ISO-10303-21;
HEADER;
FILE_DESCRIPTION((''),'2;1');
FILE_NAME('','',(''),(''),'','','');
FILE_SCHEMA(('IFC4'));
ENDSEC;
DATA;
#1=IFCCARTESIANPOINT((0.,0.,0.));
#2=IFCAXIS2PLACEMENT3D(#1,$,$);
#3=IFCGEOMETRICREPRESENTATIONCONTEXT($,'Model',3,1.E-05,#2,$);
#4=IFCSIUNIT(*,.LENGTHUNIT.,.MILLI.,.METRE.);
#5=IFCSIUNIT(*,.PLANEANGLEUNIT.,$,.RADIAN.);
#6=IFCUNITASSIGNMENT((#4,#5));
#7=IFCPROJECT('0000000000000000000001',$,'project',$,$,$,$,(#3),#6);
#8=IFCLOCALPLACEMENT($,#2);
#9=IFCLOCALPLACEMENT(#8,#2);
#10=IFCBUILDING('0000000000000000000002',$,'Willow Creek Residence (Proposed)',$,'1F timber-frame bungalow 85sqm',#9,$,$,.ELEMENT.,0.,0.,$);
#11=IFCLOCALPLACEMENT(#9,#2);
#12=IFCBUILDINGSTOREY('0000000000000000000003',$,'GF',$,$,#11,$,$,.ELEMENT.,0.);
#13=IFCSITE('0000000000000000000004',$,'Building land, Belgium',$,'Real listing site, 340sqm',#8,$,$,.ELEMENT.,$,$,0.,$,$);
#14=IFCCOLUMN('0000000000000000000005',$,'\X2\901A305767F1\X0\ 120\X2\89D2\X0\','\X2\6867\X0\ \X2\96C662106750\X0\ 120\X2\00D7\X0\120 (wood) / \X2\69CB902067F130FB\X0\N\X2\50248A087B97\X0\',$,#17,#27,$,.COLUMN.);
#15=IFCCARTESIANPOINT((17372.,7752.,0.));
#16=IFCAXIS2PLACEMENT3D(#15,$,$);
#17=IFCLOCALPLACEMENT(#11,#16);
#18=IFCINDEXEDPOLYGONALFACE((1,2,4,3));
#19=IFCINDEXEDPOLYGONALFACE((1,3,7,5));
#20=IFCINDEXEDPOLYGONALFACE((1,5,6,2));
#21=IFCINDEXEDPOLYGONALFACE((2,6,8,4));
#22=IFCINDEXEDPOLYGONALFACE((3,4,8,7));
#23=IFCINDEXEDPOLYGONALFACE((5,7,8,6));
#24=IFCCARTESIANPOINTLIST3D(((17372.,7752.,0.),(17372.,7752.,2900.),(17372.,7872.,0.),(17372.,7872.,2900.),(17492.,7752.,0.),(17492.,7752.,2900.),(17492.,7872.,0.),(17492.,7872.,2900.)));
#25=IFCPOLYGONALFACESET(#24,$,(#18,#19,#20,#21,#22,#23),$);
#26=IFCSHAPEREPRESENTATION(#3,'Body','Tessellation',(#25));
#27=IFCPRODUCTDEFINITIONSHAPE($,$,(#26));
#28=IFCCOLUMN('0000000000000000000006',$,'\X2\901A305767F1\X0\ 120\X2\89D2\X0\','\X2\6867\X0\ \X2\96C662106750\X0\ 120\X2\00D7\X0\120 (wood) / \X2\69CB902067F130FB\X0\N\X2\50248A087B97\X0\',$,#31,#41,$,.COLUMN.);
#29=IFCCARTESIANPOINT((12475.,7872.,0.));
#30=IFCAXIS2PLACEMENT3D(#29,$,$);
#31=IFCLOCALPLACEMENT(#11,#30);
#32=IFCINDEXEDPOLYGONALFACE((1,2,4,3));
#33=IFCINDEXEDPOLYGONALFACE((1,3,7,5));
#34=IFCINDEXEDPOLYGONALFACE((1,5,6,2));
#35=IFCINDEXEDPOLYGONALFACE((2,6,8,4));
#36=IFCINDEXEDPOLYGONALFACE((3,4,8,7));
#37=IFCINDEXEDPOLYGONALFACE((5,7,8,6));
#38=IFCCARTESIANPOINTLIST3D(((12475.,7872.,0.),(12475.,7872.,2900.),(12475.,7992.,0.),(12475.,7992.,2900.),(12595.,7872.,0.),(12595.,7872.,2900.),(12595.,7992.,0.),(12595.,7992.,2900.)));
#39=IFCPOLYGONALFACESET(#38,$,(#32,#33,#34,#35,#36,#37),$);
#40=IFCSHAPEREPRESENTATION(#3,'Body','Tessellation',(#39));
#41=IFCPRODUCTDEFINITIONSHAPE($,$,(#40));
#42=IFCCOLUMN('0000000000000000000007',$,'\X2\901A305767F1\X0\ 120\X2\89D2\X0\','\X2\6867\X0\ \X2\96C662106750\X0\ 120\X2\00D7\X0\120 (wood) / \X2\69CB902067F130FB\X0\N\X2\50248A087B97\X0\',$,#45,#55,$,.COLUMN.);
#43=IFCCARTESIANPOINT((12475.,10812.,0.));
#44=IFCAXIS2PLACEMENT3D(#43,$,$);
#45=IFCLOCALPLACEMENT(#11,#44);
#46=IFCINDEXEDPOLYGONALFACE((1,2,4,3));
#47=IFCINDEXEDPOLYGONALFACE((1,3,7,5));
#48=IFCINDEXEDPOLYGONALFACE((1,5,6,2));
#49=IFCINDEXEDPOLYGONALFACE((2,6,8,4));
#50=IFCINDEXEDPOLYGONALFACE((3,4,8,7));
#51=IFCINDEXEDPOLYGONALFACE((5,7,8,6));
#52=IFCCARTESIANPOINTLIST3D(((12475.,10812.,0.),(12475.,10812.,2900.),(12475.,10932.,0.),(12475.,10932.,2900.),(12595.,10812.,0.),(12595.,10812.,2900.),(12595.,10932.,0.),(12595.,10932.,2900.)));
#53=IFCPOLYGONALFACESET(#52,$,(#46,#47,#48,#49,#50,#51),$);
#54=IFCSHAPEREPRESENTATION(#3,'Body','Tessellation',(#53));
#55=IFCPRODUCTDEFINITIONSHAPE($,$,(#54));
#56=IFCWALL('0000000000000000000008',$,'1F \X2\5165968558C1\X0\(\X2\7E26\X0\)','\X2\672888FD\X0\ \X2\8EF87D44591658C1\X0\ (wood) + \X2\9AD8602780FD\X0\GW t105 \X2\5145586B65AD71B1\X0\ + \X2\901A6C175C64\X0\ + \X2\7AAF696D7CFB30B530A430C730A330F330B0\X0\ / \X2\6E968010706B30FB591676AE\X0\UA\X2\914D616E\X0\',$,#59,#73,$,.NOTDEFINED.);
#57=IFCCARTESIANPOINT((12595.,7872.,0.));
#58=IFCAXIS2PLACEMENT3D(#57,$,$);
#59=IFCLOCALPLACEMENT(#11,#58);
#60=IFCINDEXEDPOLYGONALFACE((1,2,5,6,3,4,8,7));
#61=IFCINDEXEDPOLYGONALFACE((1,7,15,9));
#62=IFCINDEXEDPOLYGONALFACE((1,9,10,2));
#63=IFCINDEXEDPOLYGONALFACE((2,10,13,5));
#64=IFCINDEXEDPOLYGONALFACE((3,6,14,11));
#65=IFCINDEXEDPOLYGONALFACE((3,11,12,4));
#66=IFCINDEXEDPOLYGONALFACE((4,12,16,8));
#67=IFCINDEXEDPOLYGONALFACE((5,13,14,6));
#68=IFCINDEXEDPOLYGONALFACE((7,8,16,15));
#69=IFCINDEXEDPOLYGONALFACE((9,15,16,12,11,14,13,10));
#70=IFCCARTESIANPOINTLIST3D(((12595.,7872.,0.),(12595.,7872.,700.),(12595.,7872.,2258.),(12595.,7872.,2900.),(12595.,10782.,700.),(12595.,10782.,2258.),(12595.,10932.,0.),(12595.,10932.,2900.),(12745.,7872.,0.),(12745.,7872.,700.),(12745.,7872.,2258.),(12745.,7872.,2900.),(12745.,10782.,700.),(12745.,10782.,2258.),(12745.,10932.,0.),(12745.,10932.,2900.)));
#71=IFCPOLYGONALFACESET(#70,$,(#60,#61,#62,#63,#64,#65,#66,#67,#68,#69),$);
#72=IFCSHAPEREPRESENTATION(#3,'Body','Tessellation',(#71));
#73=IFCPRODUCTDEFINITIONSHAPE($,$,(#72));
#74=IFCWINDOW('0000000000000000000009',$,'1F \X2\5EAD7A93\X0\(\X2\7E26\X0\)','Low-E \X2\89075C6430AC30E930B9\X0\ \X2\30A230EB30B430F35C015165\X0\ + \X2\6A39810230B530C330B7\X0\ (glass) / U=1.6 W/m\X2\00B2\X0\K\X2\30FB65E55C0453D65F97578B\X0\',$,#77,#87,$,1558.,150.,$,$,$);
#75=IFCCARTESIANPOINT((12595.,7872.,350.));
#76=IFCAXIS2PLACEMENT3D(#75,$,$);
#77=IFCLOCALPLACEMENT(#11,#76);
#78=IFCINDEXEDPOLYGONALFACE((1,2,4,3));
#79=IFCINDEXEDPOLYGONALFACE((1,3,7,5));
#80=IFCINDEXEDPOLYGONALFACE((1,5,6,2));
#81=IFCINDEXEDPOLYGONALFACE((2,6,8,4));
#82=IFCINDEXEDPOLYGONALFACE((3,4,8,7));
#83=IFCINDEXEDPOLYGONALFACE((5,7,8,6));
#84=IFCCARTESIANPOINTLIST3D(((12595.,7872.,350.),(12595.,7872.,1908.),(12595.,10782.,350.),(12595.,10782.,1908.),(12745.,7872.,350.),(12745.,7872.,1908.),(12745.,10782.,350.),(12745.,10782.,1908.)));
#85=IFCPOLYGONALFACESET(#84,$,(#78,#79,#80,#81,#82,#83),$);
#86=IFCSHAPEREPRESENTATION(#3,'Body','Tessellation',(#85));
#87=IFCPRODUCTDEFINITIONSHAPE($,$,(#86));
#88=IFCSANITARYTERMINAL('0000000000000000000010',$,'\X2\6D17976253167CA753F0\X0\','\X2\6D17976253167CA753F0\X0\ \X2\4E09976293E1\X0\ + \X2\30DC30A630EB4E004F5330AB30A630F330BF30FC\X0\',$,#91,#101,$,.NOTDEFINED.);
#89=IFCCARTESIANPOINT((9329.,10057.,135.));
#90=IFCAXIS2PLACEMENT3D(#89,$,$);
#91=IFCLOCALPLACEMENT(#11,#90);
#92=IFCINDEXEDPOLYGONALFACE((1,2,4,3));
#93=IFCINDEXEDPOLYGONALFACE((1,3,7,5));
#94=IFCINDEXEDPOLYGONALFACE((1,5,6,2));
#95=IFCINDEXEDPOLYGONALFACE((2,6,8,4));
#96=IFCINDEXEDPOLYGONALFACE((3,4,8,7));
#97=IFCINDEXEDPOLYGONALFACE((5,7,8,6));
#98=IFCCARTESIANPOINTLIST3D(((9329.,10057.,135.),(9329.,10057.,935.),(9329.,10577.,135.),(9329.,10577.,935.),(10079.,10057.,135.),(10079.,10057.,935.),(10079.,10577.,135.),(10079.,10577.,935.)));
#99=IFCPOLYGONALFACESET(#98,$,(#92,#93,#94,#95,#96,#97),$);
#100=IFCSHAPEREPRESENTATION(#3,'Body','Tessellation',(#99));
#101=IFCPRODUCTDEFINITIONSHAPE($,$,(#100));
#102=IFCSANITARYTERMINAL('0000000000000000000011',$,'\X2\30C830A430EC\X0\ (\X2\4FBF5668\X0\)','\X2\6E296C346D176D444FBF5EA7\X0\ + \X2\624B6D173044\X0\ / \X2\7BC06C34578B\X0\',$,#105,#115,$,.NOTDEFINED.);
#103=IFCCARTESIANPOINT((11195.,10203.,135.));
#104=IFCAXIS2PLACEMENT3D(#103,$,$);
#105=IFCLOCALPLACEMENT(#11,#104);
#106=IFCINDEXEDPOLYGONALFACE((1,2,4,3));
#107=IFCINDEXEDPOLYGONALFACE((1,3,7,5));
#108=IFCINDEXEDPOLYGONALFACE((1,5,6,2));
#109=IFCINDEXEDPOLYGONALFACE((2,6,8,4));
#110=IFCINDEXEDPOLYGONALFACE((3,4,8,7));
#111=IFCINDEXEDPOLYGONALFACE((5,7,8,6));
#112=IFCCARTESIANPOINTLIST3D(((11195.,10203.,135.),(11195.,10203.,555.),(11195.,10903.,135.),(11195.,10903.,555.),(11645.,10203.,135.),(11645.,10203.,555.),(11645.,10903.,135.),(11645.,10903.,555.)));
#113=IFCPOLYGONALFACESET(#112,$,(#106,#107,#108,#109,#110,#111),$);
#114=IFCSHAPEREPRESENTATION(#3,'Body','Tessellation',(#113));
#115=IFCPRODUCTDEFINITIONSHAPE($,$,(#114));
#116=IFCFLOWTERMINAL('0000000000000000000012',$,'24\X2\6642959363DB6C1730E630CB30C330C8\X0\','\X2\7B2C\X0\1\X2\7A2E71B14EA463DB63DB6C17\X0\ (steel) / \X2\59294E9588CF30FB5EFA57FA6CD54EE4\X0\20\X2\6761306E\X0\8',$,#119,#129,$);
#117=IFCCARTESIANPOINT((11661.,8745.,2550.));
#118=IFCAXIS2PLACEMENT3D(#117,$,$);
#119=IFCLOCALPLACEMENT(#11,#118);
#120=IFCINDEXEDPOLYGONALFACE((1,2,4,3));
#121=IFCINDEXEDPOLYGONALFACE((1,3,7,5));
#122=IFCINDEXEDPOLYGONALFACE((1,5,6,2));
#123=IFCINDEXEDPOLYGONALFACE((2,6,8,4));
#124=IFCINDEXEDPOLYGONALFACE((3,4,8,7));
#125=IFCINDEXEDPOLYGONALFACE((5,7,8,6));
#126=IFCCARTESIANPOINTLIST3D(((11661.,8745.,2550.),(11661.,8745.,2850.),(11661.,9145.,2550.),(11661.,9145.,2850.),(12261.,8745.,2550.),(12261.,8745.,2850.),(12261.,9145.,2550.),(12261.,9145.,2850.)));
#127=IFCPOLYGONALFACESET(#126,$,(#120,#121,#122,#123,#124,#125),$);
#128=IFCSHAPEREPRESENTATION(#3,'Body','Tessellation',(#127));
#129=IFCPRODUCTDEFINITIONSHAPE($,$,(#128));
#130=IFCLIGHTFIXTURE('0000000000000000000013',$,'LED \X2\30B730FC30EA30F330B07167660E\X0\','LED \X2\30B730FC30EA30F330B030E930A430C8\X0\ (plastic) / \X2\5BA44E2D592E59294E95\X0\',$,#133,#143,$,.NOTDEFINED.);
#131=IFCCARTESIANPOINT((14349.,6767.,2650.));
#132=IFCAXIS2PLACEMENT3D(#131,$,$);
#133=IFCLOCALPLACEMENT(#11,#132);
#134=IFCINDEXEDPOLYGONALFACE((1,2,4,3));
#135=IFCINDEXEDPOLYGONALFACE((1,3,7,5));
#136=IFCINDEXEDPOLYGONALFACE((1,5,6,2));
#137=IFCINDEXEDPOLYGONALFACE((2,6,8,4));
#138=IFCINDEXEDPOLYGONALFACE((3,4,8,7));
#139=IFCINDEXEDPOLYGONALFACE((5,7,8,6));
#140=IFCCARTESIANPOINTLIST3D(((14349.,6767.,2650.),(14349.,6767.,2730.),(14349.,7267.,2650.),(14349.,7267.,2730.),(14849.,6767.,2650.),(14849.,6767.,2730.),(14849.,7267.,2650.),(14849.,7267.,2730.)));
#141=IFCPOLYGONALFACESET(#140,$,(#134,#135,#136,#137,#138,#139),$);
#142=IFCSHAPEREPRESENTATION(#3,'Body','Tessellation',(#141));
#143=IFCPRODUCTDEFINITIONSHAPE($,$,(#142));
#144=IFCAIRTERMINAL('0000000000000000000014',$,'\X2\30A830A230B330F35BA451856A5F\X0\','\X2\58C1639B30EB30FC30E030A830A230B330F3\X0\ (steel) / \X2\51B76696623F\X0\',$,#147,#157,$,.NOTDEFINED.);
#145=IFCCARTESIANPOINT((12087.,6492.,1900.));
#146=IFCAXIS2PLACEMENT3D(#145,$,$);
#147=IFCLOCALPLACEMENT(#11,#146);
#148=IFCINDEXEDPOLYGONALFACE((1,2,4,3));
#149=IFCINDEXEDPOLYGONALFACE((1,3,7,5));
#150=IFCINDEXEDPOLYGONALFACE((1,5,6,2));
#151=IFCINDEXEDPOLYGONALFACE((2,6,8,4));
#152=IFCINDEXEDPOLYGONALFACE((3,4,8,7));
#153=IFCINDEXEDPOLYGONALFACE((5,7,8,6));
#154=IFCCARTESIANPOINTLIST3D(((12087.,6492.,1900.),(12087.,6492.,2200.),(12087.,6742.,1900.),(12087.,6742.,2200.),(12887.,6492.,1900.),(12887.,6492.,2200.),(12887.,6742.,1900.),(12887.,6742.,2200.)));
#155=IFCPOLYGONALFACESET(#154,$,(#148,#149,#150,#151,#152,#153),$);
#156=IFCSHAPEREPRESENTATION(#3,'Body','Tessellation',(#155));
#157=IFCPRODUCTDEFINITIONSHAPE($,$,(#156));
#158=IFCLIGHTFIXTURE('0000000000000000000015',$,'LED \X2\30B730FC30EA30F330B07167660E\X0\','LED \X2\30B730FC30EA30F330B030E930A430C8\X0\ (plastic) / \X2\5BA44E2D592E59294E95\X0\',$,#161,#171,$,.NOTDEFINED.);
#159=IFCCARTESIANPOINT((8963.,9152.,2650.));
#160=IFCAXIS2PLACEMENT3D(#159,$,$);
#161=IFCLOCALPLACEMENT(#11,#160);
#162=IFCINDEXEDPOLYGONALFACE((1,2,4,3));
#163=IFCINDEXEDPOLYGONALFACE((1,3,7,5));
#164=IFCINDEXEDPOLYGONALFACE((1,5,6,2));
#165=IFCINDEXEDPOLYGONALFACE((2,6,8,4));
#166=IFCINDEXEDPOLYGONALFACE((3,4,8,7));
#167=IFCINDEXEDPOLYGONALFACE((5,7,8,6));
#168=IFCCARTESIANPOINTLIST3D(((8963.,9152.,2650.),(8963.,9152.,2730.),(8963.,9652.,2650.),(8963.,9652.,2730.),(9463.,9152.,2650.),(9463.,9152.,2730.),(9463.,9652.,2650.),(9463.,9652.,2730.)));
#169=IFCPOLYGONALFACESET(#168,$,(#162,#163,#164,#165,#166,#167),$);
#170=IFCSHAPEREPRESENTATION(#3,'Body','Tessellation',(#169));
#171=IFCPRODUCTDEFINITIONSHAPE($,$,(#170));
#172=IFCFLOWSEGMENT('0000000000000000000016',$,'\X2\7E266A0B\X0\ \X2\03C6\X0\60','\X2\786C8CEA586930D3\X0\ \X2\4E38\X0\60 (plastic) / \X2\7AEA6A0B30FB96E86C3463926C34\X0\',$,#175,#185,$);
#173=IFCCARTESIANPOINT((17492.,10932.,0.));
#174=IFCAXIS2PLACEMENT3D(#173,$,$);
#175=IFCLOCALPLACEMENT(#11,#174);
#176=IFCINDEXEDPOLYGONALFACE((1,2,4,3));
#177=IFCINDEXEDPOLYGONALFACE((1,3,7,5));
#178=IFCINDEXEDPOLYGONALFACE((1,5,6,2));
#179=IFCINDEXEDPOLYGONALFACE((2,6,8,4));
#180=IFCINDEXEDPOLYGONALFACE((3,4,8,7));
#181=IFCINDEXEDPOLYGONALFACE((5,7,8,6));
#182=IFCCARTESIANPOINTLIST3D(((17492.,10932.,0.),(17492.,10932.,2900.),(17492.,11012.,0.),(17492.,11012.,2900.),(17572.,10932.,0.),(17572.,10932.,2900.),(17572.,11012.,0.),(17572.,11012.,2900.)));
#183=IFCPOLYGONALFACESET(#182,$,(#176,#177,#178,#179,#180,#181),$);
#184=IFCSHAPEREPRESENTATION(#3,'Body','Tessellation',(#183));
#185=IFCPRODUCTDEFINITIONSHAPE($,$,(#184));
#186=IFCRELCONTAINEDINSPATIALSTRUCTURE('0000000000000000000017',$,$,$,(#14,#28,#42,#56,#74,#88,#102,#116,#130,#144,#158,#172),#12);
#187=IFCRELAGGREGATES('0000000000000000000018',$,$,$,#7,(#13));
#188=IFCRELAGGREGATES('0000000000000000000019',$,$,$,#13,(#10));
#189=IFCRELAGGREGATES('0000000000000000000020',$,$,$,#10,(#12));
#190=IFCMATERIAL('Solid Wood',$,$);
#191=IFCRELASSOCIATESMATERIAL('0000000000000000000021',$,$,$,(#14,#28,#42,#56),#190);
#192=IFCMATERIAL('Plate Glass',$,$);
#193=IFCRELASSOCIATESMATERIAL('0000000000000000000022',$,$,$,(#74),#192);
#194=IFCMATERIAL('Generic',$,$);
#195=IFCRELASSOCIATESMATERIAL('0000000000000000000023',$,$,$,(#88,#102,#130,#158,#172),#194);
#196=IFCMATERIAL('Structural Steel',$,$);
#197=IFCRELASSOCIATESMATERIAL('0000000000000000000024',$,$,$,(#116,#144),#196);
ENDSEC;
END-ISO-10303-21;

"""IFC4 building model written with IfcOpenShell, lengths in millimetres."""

from ifc_helpers import new_model, si_unit, frame, frame_2d, origin, place, context, project, spatial, rectangle, extrude, material, element, fill, save


model = new_model("IFC4")

# Units and contexts
model_context = context("Model", 3, precision=1e-05, world=origin())
ifc_project = project(units=[si_unit("LENGTHUNIT", "METRE", prefix="MILLI"), si_unit("PLANEANGLEUNIT", "RADIAN")], contexts=[model_context])

# Site, building, storey
site_placement = place(None, origin())
site = spatial("IfcSite", under=ifc_project, at=site_placement, Name="Building land, Belgium", ObjectType="Real listing site, 340sqm", CompositionType="ELEMENT", RefElevation=0.0)
building_placement = place(site_placement, origin())
building = spatial("IfcBuilding", under=site, at=building_placement, Name="Willow Creek Residence (Proposed)", ObjectType="1F timber-frame bungalow 85sqm", CompositionType="ELEMENT", ElevationOfRefHeight=0.0, ElevationOfTerrain=0.0)
storey_placement = place(building_placement, origin())
storey = spatial("IfcBuildingStorey", under=building, at=storey_placement, Name="GF", CompositionType="ELEMENT", Elevation=0.0)

# Columns
ifc_material_1 = material(Name="Solid Wood")
column_1_placement = place(storey_placement, frame((17372.0, 7752.0, 0.0)))
element("IfcColumn", 1, at=column_1_placement, inside=storey, material=ifc_material_1, Name="通し柱 120角", Description="桧 集成材 120×120 (wood) / 構造柱・N値計算", PredefinedType="COLUMN", context=model_context, shape_type="SweptSolid", body=[
    extrude(rectangle(XDim=120.0, YDim=120.0, at=frame_2d((60.0, 60.0))), frame((17372.0, 7752.0, 0.0)), (0.0, 0.0, 1.0), 2900.0),
])
column_2_placement = place(storey_placement, frame((12475.0, 7872.0, 0.0)))
element("IfcColumn", 2, at=column_2_placement, inside=storey, material=ifc_material_1, Name="通し柱 120角", Description="桧 集成材 120×120 (wood) / 構造柱・N値計算", PredefinedType="COLUMN", context=model_context, shape_type="SweptSolid", body=[
    extrude(rectangle(XDim=120.0, YDim=120.0, at=frame_2d((60.0, 60.0))), frame((12475.0, 7872.0, 0.0)), (0.0, 0.0, 1.0), 2900.0),
])
column_3_placement = place(storey_placement, frame((12475.0, 10812.0, 0.0)))
element("IfcColumn", 3, at=column_3_placement, inside=storey, material=ifc_material_1, Name="通し柱 120角", Description="桧 集成材 120×120 (wood) / 構造柱・N値計算", PredefinedType="COLUMN", context=model_context, shape_type="SweptSolid", body=[
    extrude(rectangle(XDim=120.0, YDim=120.0, at=frame_2d((60.0, 60.0))), frame((12475.0, 10812.0, 0.0)), (0.0, 0.0, 1.0), 2900.0),
])

# Wall, opening, window
wall_1_placement = place(storey_placement, frame((12595.0, 7872.0, 0.0)))
wall_1 = element("IfcWall", 4, at=wall_1_placement, inside=storey, material=ifc_material_1, Name="1F 入隅壁(縦)", Description="木製 軸組外壁 (wood) + 高性能GW t105 充填断熱 + 通気層 + 窯業系サイディング / 準耐火・外皮UA配慮", PredefinedType="NOTDEFINED", context=model_context, shape_type="SweptSolid", body=[
    extrude(rectangle(XDim=150.0, YDim=3060.0, at=frame_2d((75.0, 1530.0))), frame((12595.0, 7872.0, 0.0)), (0.0, 0.0, 1.0), 2900.0),
])
opening_placement = place(storey_placement, frame((12595.0, 7872.0, 350.0)))
opening = element("IfcOpeningElement", 5, at=opening_placement, cuts=wall_1, PredefinedType="NOTDEFINED", context=model_context, shape_type="SweptSolid", body=[
    extrude(rectangle(XDim=150.0, YDim=2910.0, at=frame_2d((75.0, 1455.0))), frame((12595.0, 7872.0, 350.0)), (0.0, 0.0, 1.0), 1558.0),
])
ifc_material_2 = material(Name="Plate Glass")
window_placement = place(storey_placement, frame((12595.0, 7872.0, 350.0)))
window = element("IfcWindow", 6, at=window_placement, inside=storey, material=ifc_material_2, Name="1F 庭窓(縦)", Description="Low-E 複層ガラス アルゴン封入 + 樹脂サッシ (glass) / U=1.6 W/m²K・日射取得型", OverallHeight=1558.0, OverallWidth=150.0, context=model_context, shape_type="SweptSolid", body=[
    extrude(rectangle(XDim=150.0, YDim=2910.0, at=frame_2d((75.0, 1455.0))), frame((12595.0, 7872.0, 350.0)), (0.0, 0.0, 1.0), 1558.0),
])
fill(opening, window)

# Sanitary terminals
ifc_material_3 = material(Name="Generic")
sanitary_terminal_1_placement = place(storey_placement, frame((9329.0, 10057.0, 135.0)))
element("IfcSanitaryTerminal", 7, at=sanitary_terminal_1_placement, inside=storey, material=ifc_material_3, Name="洗面化粧台", Description="洗面化粧台 三面鏡 + ボウル一体カウンター", PredefinedType="NOTDEFINED", context=model_context, shape_type="SweptSolid", body=[
    extrude(rectangle(XDim=750.0, YDim=520.0, at=frame_2d((375.0, 260.0))), frame((9329.0, 10057.0, 135.0)), (0.0, 0.0, 1.0), 800.0),
])
sanitary_terminal_2_placement = place(storey_placement, frame((11195.0, 10203.0, 135.0)))
element("IfcSanitaryTerminal", 8, at=sanitary_terminal_2_placement, inside=storey, material=ifc_material_3, Name="トイレ (便器)", Description="温水洗浄便座 + 手洗い / 節水型", PredefinedType="NOTDEFINED", context=model_context, shape_type="SweptSolid", body=[
    extrude(rectangle(XDim=450.0, YDim=700.0, at=frame_2d((225.0, 350.0))), frame((11195.0, 10203.0, 135.0)), (0.0, 0.0, 1.0), 420.0),
])

# Flow terminal
ifc_material_4 = material(Name="Structural Steel")
flow_terminal_placement = place(storey_placement, frame((11661.0, 8745.0, 2550.0)))
element("IfcFlowTerminal", 9, at=flow_terminal_placement, inside=storey, material=ifc_material_4, Name="24時間換気ユニット", Description="第1種熱交換換気 (steel) / 天井裏・建基法令20条の8", context=model_context, shape_type="SweptSolid", body=[
    extrude(rectangle(XDim=600.0, YDim=400.0, at=frame_2d((300.0, 200.0))), frame((11661.0, 8745.0, 2550.0)), (0.0, 0.0, 1.0), 300.0),
])

# Light fixture
light_fixture_1_placement = place(storey_placement, frame((14349.0, 6767.0, 2650.0)))
element("IfcLightFixture", 10, at=light_fixture_1_placement, inside=storey, material=ifc_material_3, Name="LED シーリング照明", Description="LED シーリングライト (plastic) / 室中央天井", PredefinedType="NOTDEFINED", context=model_context, shape_type="SweptSolid", body=[
    extrude(rectangle(XDim=500.0, YDim=500.0, at=frame_2d((250.0, 250.0))), frame((14349.0, 6767.0, 2650.0)), (0.0, 0.0, 1.0), 80.0),
])

# Air terminal
air_terminal_placement = place(storey_placement, frame((12087.0, 6492.0, 1900.0)))
element("IfcAirTerminal", 11, at=air_terminal_placement, inside=storey, material=ifc_material_4, Name="エアコン室内機", Description="壁掛ルームエアコン (steel) / 冷暖房", PredefinedType="NOTDEFINED", context=model_context, shape_type="SweptSolid", body=[
    extrude(rectangle(XDim=800.0, YDim=250.0, at=frame_2d((400.0, 125.0))), frame((12087.0, 6492.0, 1900.0)), (0.0, 0.0, 1.0), 300.0),
])

# Light fixture
light_fixture_2_placement = place(storey_placement, frame((8963.0, 9152.0, 2650.0)))
element("IfcLightFixture", 12, at=light_fixture_2_placement, inside=storey, material=ifc_material_3, Name="LED シーリング照明", Description="LED シーリングライト (plastic) / 室中央天井", PredefinedType="NOTDEFINED", context=model_context, shape_type="SweptSolid", body=[
    extrude(rectangle(XDim=500.0, YDim=500.0, at=frame_2d((250.0, 250.0))), frame((8963.0, 9152.0, 2650.0)), (0.0, 0.0, 1.0), 80.0),
])

# Flow segment
flow_segment_placement = place(storey_placement, frame((17492.0, 10932.0, 0.0)))
element("IfcFlowSegment", 13, at=flow_segment_placement, inside=storey, material=ifc_material_3, Name="縦樋 φ60", Description="硬質塩ビ 丸60 (plastic) / 竪樋・雨水排水", context=model_context, shape_type="SweptSolid", body=[
    extrude(rectangle(XDim=80.0, YDim=80.0, at=frame_2d((40.0, 40.0))), frame((17492.0, 10932.0, 0.0)), (0.0, 0.0, 1.0), 2900.0),
])

save(model, "model.ifc")
